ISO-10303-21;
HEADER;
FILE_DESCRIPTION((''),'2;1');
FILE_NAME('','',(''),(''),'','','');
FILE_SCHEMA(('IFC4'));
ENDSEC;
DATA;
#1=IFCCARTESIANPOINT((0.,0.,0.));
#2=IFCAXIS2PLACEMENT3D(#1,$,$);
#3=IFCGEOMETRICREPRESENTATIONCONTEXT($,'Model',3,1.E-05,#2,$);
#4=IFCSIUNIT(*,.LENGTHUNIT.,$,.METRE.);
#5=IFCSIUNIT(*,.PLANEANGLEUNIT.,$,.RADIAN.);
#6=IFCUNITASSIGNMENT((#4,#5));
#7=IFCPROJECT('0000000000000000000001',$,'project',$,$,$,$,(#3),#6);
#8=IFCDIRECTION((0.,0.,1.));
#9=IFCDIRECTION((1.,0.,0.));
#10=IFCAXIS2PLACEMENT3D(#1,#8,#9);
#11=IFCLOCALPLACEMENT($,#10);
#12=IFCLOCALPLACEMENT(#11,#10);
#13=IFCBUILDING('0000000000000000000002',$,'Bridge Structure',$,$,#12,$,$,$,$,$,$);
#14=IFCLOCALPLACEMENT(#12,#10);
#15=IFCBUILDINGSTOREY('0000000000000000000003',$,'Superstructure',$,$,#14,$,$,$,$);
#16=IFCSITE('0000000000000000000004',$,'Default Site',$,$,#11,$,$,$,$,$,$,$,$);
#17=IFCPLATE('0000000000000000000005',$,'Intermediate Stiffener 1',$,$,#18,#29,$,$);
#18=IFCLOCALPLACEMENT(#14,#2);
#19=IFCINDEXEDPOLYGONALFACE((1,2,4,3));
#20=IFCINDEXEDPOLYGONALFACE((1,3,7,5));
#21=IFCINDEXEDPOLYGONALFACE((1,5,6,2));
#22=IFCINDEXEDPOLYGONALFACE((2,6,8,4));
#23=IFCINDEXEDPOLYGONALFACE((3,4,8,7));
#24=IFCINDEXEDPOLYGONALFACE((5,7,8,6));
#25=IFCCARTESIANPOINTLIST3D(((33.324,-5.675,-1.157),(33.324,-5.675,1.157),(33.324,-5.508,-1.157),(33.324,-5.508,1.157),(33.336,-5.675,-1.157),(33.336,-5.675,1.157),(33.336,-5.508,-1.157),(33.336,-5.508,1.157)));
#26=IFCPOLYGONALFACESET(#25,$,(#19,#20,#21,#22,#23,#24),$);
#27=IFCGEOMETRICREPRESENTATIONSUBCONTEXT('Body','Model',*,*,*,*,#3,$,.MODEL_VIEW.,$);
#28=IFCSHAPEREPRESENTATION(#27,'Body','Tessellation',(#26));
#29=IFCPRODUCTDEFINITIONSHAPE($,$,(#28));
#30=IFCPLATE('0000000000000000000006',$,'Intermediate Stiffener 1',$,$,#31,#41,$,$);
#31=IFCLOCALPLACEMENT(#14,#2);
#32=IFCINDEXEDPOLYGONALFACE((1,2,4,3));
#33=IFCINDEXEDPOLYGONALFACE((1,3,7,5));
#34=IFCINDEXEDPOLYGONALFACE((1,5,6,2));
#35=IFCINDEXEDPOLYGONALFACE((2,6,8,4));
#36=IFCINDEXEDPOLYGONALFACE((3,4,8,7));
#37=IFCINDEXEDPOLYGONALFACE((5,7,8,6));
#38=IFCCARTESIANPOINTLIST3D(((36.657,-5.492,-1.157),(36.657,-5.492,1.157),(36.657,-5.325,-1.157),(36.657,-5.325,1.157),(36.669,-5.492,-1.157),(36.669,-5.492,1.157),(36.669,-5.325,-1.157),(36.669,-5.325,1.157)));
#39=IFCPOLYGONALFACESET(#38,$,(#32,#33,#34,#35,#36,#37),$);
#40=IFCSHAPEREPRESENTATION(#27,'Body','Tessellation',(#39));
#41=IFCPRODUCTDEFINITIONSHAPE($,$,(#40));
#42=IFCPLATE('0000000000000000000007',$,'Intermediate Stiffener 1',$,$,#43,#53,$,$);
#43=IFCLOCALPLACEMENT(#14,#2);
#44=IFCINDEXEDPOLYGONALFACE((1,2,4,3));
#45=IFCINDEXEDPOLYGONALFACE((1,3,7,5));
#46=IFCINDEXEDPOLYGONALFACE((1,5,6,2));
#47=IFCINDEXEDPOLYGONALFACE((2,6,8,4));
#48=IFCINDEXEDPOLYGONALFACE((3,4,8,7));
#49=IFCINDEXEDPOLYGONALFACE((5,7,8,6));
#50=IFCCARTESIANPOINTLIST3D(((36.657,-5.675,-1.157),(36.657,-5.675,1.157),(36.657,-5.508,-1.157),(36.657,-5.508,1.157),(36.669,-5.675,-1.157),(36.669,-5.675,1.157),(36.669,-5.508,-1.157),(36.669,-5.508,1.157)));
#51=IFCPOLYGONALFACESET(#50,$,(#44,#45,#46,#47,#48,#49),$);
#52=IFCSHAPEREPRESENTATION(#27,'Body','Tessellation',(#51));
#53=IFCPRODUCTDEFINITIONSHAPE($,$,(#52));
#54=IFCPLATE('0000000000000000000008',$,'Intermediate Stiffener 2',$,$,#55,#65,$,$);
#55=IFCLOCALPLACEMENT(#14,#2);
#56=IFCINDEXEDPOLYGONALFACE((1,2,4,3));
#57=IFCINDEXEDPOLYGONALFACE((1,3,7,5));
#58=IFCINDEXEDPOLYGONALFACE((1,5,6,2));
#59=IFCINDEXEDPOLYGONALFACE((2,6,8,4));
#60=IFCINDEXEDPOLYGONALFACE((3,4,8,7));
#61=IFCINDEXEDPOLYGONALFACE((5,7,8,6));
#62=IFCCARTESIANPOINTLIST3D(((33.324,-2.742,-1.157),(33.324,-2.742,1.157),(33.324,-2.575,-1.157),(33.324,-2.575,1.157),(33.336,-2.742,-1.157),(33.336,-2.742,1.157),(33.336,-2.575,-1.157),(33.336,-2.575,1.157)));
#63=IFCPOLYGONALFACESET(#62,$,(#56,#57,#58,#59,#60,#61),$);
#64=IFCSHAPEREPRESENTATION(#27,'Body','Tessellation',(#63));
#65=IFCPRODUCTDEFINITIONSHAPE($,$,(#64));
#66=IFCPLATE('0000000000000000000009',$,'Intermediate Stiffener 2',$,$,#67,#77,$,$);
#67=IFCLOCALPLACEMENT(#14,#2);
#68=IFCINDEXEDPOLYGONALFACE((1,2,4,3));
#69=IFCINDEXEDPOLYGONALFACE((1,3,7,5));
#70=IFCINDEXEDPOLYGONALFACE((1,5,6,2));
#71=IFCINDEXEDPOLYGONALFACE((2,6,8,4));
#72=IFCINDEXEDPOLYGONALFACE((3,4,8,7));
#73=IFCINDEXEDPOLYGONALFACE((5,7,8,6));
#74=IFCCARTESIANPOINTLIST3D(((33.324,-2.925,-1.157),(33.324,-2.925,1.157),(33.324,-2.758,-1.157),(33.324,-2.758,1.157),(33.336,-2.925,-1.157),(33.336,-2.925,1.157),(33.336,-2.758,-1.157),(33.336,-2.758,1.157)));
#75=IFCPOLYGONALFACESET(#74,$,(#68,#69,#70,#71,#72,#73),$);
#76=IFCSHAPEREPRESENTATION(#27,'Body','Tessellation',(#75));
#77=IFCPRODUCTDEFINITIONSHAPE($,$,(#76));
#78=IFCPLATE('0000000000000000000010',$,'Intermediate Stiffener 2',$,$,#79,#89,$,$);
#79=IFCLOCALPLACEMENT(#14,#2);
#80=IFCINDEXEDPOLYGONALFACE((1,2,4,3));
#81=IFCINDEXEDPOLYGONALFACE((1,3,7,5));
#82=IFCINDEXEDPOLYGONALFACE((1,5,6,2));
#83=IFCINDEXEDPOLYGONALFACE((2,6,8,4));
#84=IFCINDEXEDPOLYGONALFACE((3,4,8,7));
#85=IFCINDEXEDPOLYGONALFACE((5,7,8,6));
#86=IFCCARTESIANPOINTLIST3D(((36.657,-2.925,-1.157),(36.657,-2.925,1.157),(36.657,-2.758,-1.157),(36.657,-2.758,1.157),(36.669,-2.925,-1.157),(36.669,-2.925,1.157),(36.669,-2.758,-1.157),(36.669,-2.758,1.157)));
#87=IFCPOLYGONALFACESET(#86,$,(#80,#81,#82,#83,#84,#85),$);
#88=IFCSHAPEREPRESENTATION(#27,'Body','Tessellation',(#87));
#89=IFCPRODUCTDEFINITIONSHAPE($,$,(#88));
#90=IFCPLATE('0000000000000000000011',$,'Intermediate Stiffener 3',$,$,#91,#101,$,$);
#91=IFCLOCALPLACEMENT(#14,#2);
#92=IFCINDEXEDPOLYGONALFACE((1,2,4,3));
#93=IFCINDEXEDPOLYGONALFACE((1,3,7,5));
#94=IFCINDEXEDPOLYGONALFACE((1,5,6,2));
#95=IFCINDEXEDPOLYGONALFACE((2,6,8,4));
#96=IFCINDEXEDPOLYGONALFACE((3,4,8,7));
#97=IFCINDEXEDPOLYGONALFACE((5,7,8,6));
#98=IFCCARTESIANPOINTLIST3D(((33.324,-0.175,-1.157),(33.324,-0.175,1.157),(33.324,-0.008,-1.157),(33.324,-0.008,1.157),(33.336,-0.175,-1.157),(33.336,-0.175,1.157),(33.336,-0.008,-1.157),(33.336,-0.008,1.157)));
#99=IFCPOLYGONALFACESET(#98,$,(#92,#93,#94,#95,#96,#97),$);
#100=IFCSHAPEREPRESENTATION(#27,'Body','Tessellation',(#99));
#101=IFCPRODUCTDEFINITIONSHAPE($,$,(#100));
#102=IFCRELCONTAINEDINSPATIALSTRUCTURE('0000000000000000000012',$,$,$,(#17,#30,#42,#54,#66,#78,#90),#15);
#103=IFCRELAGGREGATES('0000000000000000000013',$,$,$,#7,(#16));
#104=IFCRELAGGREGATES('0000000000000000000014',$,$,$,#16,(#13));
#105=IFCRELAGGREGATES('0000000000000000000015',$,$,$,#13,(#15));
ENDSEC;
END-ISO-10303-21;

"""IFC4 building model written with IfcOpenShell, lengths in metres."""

from ifc_helpers import new_model, si_unit, frame, origin, origin_with_axes, origin_2d_with_axis, place, context, subcontext, project, spatial, rectangle, extrude, element, save


model = new_model("IFC4")

# Units and contexts
model_context = context("Model", 3, precision=1e-05, world=origin())
body_context = subcontext(model_context, "Body", "Model", "MODEL_VIEW")
ifc_project = project(units=[si_unit("LENGTHUNIT", "METRE"), si_unit("PLANEANGLEUNIT", "RADIAN")], contexts=[model_context])

# Site, building, storey
site_placement = place(None, origin_with_axes())
site = spatial("IfcSite", under=ifc_project, at=site_placement, Name="Default Site")
building_placement = place(site_placement, origin_with_axes())
building = spatial("IfcBuilding", under=site, at=building_placement, Name="Bridge Structure")
storey_placement = place(building_placement, origin_with_axes())
storey = spatial("IfcBuildingStorey", under=building, at=storey_placement, Name="Superstructure")

# Plates
for number, where, z_axis, x_axis, name in (
    (1, (33.33, -5.5915, -1.157), (0.0, 0.0, 1.0), (1.0, 0.0, 0.0), "Intermediate Stiffener 1"),
    (2, (36.663, -5.4085, -1.157), (0.0, 0.0, 1.0), (1.0, 0.0, 0.0), "Intermediate Stiffener 1"),
    (3, (36.663, -5.5915, -1.157), (0.0, 0.0, 1.0), (1.0, 0.0, 0.0), "Intermediate Stiffener 1"),
    (4, (33.33, -2.6585, -1.157), (0.0, 0.0, 1.0), (1.0, 0.0, 0.0), "Intermediate Stiffener 2"),
    (5, (33.33, -2.8415, -1.157), (0.0, 0.0, 1.0), (1.0, 0.0, 0.0), "Intermediate Stiffener 2"),
    (6, (36.663, -2.8415, -1.157), (0.0, 0.0, 1.0), (1.0, 0.0, 0.0), "Intermediate Stiffener 2"),
    (7, (33.33, -0.0915, -1.157), (0.0, 0.0, 1.0), (1.0, 0.0, 0.0), "Intermediate Stiffener 3"),
):
    element("IfcPlate", number, at=place(storey_placement, frame(where, z_axis=z_axis, x_axis=x_axis)), inside=storey, Name=name, context=body_context, shape_type="SweptSolid", body=[
        extrude(rectangle(XDim=0.012, YDim=0.167, at=origin_2d_with_axis()), origin_with_axes(), (0.0, 0.0, 1.0), 2.314),
    ])

save(model, "model.ifc")
